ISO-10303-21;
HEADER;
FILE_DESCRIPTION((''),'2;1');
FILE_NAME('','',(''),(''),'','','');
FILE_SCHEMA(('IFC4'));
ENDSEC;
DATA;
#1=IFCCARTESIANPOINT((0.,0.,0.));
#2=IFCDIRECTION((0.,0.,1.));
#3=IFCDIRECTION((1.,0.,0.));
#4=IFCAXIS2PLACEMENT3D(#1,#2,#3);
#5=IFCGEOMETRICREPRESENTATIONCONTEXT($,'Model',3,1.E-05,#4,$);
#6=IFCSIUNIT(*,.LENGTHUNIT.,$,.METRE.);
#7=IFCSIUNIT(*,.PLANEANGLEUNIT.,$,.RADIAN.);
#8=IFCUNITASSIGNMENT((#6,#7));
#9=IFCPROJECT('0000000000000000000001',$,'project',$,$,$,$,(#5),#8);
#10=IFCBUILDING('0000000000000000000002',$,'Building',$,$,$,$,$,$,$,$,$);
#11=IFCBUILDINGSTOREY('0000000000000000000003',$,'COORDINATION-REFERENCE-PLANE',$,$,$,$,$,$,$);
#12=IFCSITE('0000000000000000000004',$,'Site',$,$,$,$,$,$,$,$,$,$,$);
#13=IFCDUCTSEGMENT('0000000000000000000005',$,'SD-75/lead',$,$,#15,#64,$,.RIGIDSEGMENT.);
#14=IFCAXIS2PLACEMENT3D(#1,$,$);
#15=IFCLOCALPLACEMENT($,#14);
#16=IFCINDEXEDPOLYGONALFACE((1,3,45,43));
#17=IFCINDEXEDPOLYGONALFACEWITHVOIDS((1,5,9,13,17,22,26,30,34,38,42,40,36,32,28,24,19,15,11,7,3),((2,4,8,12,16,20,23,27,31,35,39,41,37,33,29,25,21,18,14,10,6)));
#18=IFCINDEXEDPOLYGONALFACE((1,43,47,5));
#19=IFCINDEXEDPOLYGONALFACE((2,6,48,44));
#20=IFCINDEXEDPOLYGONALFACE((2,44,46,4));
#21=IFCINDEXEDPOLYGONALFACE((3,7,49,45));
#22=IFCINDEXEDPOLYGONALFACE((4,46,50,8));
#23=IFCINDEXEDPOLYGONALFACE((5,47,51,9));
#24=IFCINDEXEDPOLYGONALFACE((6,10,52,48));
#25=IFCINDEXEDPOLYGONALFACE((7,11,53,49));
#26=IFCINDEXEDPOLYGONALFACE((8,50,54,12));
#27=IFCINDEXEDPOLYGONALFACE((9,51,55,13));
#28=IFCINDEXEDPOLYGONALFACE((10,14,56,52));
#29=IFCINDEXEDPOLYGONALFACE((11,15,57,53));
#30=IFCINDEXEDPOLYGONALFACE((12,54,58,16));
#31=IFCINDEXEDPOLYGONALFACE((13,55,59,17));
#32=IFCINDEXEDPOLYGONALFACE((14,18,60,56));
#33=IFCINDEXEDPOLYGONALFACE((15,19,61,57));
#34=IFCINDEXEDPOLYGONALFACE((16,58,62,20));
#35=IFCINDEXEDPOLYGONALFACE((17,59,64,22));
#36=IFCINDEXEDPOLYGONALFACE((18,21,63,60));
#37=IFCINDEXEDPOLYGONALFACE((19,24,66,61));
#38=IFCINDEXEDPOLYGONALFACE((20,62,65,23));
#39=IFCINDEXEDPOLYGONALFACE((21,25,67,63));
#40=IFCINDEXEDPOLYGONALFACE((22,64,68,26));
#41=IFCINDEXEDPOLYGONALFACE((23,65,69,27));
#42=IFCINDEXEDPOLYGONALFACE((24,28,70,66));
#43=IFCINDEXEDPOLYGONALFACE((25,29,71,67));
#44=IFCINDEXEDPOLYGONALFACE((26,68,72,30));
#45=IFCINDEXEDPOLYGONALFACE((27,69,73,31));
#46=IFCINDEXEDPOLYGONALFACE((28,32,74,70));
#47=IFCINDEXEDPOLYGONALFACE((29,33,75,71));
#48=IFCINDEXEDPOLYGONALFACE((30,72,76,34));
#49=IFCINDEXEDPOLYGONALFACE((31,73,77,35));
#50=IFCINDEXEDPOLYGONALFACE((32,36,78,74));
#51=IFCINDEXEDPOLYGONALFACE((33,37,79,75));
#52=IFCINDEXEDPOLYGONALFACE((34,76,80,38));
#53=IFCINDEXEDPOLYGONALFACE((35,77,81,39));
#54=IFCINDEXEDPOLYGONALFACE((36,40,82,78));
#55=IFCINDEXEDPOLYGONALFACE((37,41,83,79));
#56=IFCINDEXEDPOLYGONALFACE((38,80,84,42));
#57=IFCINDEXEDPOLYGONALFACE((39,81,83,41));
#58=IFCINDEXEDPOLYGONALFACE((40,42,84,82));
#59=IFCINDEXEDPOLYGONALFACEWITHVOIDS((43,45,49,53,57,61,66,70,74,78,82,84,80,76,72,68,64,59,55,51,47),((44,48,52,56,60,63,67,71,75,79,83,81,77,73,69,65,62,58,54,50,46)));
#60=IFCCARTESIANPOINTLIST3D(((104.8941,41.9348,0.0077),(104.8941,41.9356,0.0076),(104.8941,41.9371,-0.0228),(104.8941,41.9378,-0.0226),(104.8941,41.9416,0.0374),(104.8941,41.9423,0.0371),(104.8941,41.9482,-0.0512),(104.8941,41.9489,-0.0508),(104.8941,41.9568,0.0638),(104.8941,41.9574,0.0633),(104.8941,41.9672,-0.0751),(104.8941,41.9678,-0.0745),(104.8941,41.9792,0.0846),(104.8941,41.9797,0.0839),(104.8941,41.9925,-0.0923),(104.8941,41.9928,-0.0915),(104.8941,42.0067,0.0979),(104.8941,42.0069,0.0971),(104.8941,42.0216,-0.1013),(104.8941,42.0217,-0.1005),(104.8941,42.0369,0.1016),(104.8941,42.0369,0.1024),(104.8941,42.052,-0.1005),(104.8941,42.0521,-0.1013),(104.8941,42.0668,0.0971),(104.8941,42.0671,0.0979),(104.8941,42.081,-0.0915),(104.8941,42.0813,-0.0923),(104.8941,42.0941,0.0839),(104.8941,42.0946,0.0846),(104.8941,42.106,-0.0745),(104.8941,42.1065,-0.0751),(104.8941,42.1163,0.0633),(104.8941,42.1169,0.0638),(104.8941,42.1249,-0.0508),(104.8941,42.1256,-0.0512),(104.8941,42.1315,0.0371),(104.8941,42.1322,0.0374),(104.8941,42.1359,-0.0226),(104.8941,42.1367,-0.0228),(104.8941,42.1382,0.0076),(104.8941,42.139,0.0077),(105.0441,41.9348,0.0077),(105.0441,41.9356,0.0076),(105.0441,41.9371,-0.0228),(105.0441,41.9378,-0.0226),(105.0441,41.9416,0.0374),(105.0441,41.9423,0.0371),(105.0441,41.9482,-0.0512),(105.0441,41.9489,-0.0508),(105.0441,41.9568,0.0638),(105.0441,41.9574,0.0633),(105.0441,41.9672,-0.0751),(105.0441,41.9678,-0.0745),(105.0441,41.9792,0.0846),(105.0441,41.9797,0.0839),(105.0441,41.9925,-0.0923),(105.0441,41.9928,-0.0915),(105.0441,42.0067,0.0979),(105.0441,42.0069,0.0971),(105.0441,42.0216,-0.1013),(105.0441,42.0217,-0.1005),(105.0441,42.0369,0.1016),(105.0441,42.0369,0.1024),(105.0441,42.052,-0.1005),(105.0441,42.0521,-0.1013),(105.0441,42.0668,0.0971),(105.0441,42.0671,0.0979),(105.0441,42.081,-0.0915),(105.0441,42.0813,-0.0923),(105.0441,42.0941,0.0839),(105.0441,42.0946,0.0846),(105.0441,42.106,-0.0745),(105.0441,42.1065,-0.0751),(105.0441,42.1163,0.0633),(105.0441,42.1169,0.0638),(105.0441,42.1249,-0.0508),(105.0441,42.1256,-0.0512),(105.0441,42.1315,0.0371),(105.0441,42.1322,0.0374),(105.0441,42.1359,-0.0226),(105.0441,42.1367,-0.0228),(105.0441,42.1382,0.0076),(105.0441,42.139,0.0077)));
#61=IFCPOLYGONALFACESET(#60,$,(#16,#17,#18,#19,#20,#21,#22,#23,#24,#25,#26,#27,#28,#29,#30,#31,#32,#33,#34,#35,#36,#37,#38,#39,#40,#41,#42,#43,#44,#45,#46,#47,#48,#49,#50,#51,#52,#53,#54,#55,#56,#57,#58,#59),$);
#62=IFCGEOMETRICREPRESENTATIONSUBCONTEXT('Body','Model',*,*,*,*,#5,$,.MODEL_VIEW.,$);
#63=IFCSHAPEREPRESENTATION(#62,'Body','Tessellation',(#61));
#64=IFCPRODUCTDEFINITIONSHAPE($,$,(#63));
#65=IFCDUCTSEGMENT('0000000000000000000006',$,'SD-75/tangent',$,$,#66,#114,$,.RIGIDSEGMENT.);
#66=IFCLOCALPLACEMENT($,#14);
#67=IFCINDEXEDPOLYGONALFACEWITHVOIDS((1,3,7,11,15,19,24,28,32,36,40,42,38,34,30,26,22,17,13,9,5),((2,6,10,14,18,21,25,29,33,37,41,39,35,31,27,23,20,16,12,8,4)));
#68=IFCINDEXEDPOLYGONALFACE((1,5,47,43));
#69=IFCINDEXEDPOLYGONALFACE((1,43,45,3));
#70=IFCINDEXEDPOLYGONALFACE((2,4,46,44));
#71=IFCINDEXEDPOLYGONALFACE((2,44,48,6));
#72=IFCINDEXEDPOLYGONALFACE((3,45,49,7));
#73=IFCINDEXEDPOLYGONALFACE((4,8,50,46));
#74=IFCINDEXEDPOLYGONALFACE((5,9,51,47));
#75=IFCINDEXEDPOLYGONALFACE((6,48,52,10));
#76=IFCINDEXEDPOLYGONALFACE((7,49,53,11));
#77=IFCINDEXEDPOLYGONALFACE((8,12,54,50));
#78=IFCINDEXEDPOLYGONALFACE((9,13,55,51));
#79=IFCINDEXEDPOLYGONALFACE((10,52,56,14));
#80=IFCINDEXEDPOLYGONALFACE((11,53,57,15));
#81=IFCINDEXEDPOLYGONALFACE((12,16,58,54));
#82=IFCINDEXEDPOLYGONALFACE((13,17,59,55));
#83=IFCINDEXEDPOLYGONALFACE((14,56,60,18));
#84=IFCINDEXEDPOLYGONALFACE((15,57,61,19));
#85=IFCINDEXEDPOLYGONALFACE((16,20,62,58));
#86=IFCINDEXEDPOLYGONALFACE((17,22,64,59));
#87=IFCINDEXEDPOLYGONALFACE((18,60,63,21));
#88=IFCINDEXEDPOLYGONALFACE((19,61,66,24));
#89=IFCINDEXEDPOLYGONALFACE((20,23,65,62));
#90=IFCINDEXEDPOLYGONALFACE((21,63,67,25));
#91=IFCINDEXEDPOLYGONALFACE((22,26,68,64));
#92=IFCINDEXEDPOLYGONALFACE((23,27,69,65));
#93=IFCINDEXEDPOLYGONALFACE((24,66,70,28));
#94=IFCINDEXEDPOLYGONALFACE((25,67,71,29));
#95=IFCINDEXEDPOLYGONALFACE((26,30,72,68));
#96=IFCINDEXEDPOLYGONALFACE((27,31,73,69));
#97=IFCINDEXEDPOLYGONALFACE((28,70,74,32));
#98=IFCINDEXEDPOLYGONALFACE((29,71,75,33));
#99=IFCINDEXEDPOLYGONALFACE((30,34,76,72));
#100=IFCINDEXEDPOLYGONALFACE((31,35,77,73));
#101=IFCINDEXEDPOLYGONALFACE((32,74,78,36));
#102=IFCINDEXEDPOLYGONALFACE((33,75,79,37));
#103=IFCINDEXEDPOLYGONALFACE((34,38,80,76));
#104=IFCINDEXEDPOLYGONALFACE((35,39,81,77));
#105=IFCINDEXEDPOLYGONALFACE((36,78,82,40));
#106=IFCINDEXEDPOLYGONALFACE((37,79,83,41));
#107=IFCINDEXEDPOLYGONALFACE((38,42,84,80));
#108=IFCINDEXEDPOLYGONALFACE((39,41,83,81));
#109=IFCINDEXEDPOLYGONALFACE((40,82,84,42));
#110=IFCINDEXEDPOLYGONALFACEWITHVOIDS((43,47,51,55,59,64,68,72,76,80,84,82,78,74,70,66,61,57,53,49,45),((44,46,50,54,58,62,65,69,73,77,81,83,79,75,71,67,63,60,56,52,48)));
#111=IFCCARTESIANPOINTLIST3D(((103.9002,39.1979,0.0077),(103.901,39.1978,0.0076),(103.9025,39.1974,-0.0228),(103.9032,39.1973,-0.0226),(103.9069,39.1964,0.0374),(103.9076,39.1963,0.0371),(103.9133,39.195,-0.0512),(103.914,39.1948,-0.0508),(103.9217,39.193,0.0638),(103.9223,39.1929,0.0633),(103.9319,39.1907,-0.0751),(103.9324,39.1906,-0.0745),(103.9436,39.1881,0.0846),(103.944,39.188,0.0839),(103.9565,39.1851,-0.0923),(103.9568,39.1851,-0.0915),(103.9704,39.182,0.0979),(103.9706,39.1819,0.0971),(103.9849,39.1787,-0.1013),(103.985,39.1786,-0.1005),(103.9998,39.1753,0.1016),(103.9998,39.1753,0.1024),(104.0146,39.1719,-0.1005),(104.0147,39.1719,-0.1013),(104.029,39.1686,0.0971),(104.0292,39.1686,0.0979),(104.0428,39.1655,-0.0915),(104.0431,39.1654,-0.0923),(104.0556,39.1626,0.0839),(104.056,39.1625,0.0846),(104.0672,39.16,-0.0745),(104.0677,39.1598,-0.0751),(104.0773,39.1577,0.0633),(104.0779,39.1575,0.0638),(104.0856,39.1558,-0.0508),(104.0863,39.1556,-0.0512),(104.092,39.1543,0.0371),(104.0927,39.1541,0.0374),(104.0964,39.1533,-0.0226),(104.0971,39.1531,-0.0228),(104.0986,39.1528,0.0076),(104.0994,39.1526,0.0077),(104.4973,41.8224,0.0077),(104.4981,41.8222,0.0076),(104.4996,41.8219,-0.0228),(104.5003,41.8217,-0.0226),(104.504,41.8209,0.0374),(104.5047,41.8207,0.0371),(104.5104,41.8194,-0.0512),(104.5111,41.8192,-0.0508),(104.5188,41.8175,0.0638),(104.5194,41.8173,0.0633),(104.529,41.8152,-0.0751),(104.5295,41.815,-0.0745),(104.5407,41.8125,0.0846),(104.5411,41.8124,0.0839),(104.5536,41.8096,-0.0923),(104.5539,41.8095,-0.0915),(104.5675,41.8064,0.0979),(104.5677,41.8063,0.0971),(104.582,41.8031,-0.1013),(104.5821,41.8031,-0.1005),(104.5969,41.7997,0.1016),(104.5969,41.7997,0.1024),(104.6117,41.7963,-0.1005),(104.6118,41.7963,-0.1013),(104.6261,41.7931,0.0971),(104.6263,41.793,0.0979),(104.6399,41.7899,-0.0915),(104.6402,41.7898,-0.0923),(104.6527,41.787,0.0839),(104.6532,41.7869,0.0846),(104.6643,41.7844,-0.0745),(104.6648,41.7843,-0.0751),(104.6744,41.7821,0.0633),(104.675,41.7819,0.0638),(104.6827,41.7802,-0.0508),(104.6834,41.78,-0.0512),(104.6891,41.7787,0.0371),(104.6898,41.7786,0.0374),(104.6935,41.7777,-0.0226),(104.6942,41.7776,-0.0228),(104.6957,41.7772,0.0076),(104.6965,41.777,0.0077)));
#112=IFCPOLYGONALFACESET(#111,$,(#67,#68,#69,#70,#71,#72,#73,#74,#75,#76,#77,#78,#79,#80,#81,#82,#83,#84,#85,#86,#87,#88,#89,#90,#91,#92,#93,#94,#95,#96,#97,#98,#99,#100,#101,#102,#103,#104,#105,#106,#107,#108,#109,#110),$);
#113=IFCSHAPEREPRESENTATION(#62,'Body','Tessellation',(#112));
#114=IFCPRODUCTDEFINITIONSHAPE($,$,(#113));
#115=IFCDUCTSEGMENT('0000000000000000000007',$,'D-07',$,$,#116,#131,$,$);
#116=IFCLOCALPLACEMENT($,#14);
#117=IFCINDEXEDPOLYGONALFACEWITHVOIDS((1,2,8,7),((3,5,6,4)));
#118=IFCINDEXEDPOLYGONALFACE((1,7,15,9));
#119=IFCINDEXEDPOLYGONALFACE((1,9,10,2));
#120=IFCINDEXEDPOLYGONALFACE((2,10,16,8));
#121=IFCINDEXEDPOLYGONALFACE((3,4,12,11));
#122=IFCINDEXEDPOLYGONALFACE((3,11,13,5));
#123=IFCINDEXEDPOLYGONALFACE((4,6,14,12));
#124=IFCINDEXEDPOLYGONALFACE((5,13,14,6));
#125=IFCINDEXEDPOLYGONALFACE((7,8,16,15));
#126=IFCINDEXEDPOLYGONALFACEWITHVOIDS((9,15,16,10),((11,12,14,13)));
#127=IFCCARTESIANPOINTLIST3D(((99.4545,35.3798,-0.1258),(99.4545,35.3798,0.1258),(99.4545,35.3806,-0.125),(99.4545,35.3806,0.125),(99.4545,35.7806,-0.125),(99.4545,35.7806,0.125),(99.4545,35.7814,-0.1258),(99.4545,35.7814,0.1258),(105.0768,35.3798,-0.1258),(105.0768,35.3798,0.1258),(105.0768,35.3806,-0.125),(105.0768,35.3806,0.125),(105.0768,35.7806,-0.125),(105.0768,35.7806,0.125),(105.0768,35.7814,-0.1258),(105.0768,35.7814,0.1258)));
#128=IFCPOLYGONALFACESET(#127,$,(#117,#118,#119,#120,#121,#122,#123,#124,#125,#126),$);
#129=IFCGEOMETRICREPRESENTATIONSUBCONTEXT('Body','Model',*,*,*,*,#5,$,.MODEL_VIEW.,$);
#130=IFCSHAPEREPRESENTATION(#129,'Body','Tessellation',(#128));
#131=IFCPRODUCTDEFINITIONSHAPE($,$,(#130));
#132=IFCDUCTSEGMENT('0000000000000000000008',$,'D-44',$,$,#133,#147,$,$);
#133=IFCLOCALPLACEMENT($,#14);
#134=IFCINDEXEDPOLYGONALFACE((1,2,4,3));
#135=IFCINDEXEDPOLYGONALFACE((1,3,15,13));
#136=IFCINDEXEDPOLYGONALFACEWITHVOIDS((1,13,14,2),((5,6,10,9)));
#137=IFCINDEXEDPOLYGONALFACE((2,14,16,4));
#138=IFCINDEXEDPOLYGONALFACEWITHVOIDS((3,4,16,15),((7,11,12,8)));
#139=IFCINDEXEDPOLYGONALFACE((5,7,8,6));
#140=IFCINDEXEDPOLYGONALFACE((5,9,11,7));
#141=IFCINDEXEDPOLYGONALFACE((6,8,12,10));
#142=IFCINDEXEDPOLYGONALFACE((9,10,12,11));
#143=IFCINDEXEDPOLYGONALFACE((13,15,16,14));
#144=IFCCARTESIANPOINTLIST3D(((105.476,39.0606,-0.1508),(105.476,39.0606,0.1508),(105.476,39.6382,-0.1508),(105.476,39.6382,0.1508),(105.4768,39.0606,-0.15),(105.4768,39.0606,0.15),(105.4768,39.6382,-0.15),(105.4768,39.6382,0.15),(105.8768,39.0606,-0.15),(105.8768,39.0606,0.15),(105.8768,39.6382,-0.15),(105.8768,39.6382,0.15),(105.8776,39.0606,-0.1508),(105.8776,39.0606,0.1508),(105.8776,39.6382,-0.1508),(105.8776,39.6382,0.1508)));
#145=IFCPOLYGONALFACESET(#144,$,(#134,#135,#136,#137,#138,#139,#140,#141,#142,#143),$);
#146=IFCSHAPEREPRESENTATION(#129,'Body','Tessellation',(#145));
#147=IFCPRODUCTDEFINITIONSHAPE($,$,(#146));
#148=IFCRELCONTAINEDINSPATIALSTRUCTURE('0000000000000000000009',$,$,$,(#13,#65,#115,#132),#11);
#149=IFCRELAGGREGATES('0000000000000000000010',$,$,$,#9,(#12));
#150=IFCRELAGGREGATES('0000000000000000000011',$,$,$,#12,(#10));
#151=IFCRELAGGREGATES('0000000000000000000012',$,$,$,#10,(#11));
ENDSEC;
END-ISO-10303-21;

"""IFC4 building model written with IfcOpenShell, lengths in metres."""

from ifc_helpers import new_model, si_unit, frame, origin, origin_with_axes, place, context, subcontext, project, spatial, hollow_rectangle, hollow_circle, extrude, element, save


model = new_model("IFC4")

# Units and contexts
model_context_1 = context("Model", 3, precision=1e-05, world=origin_with_axes())
body_context_1 = subcontext(model_context_1, "Body", "Model", "MODEL_VIEW")
body_context_2 = subcontext(model_context_1, "Body", "Model", "MODEL_VIEW")
ifc_project = project(units=[si_unit("LENGTHUNIT", "METRE"), si_unit("PLANEANGLEUNIT", "RADIAN")], contexts=[model_context_1])

# Site, building, storey
site = spatial("IfcSite", under=ifc_project, Name="Site")
building = spatial("IfcBuilding", under=site, Name="Building")
storey = spatial("IfcBuildingStorey", under=building, Name="COORDINATION-REFERENCE-PLANE")

# Duct segment
duct_segment_1_placement = place(None, frame((105.0441, 42.0369, 0.0), z_axis=(-1.0, 0.0, 0.0), x_axis=(0.0, 0.0, 1.0)))
element("IfcDuctSegment", 1, at=duct_segment_1_placement, inside=storey, Name="SD-75/lead", PredefinedType="RIGIDSEGMENT", context=body_context_1, shape_type="SweptSolid", body=[
    extrude(hollow_circle(Radius=0.1024, WallThickness=0.0008), origin_with_axes(), (0.0, 0.0, 1.0), 0.15),
])

# Duct segment
duct_segment_2_placement = place(None, frame((104.5969, 41.7997, 0.0), z_axis=(-0.221849, -0.975081, 0.0), x_axis=(0.0, 0.0, 1.0)))
element("IfcDuctSegment", 2, at=duct_segment_2_placement, inside=storey, Name="SD-75/tangent", PredefinedType="RIGIDSEGMENT", context=body_context_1, shape_type="SweptSolid", body=[
    extrude(hollow_circle(Radius=0.1024, WallThickness=0.0008), origin_with_axes(), (0.0, 0.0, 1.0), 2.6915),
])

# Duct segments
duct_segment_3_placement = place(None, frame((99.4545, 35.5806, 0.0), z_axis=(1.0, 0.0, 0.0), x_axis=(0.0, 1.0, 0.0)))
element("IfcDuctSegment", 3, at=duct_segment_3_placement, inside=storey, Name="D-07", context=body_context_2, shape_type="SweptSolid", body=[
    extrude(hollow_rectangle(XDim=0.4016, YDim=0.2516, WallThickness=0.0008), origin(), (0.0, 0.0, 1.0), 5.6223),
])
duct_segment_4_placement = place(None, frame((105.6768, 39.0606, 0.0), z_axis=(0.0, 1.0, 0.0), x_axis=(1.0, 0.0, 0.0)))
element("IfcDuctSegment", 4, at=duct_segment_4_placement, inside=storey, Name="D-44", context=body_context_2, shape_type="SweptSolid", body=[
    extrude(hollow_rectangle(XDim=0.4016, YDim=0.3016, WallThickness=0.0008), origin(), (0.0, 0.0, 1.0), 0.5776),
])

save(model, "model.ifc")
